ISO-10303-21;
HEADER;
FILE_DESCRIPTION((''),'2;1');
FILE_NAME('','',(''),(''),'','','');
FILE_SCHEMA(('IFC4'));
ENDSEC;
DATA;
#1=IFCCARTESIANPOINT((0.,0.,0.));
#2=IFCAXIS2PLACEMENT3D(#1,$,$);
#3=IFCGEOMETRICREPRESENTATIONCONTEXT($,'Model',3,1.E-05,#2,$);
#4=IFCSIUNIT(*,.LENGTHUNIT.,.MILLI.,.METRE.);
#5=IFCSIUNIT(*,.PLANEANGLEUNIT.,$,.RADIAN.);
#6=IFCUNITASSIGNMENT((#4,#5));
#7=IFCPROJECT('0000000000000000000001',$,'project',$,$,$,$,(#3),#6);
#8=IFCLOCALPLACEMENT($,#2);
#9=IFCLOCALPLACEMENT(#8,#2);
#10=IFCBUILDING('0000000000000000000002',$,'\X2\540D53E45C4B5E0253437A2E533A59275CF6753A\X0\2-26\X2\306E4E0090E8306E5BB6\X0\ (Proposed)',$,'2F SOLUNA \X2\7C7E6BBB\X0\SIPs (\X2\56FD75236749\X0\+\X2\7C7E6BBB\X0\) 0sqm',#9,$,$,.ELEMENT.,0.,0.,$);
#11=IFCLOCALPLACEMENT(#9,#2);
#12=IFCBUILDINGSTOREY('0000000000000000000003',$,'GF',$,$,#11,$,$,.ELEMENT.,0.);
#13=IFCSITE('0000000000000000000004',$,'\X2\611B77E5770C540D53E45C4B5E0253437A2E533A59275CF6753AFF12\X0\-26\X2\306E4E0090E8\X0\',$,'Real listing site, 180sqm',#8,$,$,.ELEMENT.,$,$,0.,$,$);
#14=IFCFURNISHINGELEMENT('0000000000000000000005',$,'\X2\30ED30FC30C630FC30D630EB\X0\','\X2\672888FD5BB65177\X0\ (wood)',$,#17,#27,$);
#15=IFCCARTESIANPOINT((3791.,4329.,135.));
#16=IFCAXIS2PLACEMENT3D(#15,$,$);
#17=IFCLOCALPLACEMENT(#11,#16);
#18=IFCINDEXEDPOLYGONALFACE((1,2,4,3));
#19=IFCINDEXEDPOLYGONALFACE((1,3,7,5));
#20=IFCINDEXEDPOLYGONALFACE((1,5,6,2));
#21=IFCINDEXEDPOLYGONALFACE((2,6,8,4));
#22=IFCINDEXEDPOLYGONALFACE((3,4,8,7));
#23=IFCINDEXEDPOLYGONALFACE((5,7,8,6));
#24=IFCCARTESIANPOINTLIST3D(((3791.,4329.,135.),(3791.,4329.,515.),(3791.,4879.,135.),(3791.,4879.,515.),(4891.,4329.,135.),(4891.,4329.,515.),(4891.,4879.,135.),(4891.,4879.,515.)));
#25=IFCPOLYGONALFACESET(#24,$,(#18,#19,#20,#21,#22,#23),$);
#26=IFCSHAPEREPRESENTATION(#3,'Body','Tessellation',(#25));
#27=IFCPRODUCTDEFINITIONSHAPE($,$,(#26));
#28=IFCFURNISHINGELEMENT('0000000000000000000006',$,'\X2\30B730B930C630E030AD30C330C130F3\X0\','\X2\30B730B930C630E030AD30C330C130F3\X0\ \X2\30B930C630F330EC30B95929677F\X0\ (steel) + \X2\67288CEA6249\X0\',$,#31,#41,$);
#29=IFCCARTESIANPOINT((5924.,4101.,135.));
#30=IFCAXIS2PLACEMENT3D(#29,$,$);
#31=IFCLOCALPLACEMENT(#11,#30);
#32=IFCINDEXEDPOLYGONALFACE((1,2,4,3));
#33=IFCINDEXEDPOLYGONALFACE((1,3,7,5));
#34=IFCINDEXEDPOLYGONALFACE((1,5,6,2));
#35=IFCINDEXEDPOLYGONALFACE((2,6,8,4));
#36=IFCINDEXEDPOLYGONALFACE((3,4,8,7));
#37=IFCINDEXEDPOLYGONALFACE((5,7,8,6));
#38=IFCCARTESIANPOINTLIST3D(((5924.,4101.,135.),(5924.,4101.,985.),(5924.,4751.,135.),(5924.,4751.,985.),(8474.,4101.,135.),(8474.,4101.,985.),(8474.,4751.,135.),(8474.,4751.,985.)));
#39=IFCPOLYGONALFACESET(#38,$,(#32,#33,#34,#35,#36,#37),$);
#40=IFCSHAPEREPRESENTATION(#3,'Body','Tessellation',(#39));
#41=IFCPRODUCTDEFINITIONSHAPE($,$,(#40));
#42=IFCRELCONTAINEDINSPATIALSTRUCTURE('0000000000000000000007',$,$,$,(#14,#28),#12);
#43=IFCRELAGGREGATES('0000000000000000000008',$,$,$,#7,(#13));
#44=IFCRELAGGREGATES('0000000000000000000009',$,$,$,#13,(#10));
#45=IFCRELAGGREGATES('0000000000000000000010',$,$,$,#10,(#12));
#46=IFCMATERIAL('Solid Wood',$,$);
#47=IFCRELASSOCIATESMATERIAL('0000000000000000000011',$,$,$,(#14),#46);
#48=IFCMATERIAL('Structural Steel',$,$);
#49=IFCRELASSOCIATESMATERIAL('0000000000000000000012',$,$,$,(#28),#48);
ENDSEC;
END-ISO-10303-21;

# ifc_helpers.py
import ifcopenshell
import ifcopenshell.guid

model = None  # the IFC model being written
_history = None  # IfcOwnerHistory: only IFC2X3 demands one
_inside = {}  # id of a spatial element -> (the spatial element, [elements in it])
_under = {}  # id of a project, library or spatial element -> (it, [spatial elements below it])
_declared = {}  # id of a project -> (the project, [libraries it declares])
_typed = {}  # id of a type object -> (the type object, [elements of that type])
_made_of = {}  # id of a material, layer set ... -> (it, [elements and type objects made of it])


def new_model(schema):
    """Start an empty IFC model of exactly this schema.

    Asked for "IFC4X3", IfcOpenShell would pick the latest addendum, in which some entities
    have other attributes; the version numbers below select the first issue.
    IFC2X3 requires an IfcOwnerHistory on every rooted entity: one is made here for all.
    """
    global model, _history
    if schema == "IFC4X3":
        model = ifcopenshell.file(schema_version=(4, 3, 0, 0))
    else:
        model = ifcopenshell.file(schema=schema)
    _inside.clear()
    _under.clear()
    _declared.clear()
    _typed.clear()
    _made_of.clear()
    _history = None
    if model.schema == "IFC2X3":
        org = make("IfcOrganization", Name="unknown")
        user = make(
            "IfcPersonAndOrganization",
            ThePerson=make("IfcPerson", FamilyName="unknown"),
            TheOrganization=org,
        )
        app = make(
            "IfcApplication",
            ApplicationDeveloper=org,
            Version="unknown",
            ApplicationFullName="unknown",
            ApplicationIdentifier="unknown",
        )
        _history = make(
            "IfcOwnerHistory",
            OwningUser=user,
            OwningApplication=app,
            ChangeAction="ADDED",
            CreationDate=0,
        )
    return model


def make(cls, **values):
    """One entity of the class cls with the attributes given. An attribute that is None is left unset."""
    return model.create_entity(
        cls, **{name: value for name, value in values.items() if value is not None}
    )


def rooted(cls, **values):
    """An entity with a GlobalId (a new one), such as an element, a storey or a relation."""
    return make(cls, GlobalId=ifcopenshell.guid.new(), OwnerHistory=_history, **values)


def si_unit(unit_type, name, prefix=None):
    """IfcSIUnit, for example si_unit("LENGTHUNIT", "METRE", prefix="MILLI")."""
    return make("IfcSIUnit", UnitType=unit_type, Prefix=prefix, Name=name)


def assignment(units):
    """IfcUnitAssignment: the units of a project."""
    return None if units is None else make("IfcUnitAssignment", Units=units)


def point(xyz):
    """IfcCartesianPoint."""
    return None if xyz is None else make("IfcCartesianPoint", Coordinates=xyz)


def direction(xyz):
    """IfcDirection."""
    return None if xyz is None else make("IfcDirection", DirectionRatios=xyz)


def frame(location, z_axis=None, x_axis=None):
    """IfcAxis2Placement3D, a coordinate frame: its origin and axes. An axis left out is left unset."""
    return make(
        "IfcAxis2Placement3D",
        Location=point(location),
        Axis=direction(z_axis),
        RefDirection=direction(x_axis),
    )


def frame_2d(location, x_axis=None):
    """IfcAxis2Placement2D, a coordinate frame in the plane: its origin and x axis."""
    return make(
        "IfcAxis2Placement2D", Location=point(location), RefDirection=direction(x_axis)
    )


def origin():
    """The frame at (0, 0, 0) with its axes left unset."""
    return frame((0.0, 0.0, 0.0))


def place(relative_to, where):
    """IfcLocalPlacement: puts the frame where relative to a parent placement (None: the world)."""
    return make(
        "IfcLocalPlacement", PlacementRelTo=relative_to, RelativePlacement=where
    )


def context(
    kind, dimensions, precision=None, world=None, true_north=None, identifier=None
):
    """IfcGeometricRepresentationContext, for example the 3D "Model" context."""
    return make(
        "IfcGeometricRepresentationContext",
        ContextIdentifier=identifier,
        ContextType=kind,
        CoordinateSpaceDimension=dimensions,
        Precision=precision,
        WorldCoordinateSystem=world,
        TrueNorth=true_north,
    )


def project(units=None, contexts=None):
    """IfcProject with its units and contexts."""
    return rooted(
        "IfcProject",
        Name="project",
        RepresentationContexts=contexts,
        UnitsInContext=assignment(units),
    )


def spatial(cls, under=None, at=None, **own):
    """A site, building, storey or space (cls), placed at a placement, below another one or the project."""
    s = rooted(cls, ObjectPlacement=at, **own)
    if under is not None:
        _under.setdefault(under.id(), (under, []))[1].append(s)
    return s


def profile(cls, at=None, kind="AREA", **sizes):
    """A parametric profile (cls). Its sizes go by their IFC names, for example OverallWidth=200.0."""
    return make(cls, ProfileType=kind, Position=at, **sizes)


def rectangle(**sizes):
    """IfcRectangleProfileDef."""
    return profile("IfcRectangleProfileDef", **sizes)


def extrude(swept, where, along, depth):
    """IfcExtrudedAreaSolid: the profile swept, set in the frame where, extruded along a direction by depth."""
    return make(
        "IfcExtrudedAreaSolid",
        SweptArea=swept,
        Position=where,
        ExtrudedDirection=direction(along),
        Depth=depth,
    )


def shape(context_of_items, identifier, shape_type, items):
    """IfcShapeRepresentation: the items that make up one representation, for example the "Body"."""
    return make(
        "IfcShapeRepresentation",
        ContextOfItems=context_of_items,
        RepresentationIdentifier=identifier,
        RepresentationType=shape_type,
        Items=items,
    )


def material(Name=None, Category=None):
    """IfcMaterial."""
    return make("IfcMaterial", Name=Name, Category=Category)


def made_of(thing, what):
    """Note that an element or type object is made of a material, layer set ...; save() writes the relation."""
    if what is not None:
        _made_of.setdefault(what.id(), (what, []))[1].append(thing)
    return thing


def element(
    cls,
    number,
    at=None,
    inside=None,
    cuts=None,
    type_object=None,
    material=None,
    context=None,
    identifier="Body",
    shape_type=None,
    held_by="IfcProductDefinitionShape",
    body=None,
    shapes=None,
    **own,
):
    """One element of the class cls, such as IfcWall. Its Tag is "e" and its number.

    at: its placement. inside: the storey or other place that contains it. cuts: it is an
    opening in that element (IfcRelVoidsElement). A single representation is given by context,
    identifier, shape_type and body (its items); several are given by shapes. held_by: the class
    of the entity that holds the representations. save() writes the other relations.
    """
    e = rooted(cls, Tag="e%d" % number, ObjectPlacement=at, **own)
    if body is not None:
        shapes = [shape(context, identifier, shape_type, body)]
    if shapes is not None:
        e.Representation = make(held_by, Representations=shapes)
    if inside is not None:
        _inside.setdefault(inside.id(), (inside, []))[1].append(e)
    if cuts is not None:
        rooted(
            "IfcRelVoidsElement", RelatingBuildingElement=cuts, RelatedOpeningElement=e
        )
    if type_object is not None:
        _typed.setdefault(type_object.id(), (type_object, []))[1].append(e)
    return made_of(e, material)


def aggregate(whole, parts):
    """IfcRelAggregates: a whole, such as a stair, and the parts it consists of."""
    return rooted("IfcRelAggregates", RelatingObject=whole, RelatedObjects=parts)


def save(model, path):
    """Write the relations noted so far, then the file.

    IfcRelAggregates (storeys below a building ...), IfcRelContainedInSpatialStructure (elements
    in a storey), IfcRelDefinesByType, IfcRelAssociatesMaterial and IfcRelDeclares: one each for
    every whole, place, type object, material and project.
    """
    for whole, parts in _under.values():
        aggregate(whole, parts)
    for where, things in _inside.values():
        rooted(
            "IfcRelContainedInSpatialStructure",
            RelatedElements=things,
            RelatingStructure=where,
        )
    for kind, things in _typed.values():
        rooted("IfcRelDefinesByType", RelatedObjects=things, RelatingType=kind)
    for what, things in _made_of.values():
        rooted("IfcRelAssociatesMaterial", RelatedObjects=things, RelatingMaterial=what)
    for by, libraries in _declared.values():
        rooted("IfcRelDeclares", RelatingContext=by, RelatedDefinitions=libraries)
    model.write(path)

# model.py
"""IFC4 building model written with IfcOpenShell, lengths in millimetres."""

from ifc_helpers import new_model, si_unit, frame, frame_2d, origin, place, context, project, spatial, rectangle, extrude, material, element, save


model = new_model("IFC4")

# Units and contexts
model_context = context("Model", 3, precision=1e-05, world=origin())
ifc_project = project(units=[si_unit("LENGTHUNIT", "METRE", prefix="MILLI"), si_unit("PLANEANGLEUNIT", "RADIAN")], contexts=[model_context])

# Site, building, storey
site_placement = place(None, origin())
site = spatial("IfcSite", under=ifc_project, at=site_placement, Name="愛知県名古屋市千種区大島町２-26の一部", ObjectType="Real listing site, 180sqm", CompositionType="ELEMENT", RefElevation=0.0)
building_placement = place(site_placement, origin())
building = spatial("IfcBuilding", under=site, at=building_placement, Name="名古屋市千種区大島町2-26の一部の家 (Proposed)", ObjectType="2F SOLUNA 籾殻SIPs (国産杉+籾殻) 0sqm", CompositionType="ELEMENT", ElevationOfRefHeight=0.0, ElevationOfTerrain=0.0)
storey_placement = place(building_placement, origin())
storey = spatial("IfcBuildingStorey", under=building, at=storey_placement, Name="GF", CompositionType="ELEMENT", Elevation=0.0)

# Shared definitions
ifc_material_1 = material(Name="Solid Wood")

# Furnishing elements
furnishing_1_placement = place(storey_placement, frame((3791.0, 4329.0, 135.0)))
element("IfcFurnishingElement", 1, at=furnishing_1_placement, inside=storey, material=ifc_material_1, Name="ローテーブル", Description="木製家具 (wood)", context=model_context, shape_type="SweptSolid", body=[
    extrude(rectangle(XDim=1100.0, YDim=550.0, at=frame_2d((550.0, 275.0))), frame((3791.0, 4329.0, 135.0)), (0.0, 0.0, 1.0), 380.0),
])
ifc_material_2 = material(Name="Structural Steel")
furnishing_2_placement = place(storey_placement, frame((5924.0, 4101.0, 135.0)))
element("IfcFurnishingElement", 2, at=furnishing_2_placement, inside=storey, material=ifc_material_2, Name="システムキッチン", Description="システムキッチン ステンレス天板 (steel) + 木質扉", context=model_context, shape_type="SweptSolid", body=[
    extrude(rectangle(XDim=2550.0, YDim=650.0, at=frame_2d((1275.0, 325.0))), frame((5924.0, 4101.0, 135.0)), (0.0, 0.0, 1.0), 850.0),
])

save(model, "model.ifc")
